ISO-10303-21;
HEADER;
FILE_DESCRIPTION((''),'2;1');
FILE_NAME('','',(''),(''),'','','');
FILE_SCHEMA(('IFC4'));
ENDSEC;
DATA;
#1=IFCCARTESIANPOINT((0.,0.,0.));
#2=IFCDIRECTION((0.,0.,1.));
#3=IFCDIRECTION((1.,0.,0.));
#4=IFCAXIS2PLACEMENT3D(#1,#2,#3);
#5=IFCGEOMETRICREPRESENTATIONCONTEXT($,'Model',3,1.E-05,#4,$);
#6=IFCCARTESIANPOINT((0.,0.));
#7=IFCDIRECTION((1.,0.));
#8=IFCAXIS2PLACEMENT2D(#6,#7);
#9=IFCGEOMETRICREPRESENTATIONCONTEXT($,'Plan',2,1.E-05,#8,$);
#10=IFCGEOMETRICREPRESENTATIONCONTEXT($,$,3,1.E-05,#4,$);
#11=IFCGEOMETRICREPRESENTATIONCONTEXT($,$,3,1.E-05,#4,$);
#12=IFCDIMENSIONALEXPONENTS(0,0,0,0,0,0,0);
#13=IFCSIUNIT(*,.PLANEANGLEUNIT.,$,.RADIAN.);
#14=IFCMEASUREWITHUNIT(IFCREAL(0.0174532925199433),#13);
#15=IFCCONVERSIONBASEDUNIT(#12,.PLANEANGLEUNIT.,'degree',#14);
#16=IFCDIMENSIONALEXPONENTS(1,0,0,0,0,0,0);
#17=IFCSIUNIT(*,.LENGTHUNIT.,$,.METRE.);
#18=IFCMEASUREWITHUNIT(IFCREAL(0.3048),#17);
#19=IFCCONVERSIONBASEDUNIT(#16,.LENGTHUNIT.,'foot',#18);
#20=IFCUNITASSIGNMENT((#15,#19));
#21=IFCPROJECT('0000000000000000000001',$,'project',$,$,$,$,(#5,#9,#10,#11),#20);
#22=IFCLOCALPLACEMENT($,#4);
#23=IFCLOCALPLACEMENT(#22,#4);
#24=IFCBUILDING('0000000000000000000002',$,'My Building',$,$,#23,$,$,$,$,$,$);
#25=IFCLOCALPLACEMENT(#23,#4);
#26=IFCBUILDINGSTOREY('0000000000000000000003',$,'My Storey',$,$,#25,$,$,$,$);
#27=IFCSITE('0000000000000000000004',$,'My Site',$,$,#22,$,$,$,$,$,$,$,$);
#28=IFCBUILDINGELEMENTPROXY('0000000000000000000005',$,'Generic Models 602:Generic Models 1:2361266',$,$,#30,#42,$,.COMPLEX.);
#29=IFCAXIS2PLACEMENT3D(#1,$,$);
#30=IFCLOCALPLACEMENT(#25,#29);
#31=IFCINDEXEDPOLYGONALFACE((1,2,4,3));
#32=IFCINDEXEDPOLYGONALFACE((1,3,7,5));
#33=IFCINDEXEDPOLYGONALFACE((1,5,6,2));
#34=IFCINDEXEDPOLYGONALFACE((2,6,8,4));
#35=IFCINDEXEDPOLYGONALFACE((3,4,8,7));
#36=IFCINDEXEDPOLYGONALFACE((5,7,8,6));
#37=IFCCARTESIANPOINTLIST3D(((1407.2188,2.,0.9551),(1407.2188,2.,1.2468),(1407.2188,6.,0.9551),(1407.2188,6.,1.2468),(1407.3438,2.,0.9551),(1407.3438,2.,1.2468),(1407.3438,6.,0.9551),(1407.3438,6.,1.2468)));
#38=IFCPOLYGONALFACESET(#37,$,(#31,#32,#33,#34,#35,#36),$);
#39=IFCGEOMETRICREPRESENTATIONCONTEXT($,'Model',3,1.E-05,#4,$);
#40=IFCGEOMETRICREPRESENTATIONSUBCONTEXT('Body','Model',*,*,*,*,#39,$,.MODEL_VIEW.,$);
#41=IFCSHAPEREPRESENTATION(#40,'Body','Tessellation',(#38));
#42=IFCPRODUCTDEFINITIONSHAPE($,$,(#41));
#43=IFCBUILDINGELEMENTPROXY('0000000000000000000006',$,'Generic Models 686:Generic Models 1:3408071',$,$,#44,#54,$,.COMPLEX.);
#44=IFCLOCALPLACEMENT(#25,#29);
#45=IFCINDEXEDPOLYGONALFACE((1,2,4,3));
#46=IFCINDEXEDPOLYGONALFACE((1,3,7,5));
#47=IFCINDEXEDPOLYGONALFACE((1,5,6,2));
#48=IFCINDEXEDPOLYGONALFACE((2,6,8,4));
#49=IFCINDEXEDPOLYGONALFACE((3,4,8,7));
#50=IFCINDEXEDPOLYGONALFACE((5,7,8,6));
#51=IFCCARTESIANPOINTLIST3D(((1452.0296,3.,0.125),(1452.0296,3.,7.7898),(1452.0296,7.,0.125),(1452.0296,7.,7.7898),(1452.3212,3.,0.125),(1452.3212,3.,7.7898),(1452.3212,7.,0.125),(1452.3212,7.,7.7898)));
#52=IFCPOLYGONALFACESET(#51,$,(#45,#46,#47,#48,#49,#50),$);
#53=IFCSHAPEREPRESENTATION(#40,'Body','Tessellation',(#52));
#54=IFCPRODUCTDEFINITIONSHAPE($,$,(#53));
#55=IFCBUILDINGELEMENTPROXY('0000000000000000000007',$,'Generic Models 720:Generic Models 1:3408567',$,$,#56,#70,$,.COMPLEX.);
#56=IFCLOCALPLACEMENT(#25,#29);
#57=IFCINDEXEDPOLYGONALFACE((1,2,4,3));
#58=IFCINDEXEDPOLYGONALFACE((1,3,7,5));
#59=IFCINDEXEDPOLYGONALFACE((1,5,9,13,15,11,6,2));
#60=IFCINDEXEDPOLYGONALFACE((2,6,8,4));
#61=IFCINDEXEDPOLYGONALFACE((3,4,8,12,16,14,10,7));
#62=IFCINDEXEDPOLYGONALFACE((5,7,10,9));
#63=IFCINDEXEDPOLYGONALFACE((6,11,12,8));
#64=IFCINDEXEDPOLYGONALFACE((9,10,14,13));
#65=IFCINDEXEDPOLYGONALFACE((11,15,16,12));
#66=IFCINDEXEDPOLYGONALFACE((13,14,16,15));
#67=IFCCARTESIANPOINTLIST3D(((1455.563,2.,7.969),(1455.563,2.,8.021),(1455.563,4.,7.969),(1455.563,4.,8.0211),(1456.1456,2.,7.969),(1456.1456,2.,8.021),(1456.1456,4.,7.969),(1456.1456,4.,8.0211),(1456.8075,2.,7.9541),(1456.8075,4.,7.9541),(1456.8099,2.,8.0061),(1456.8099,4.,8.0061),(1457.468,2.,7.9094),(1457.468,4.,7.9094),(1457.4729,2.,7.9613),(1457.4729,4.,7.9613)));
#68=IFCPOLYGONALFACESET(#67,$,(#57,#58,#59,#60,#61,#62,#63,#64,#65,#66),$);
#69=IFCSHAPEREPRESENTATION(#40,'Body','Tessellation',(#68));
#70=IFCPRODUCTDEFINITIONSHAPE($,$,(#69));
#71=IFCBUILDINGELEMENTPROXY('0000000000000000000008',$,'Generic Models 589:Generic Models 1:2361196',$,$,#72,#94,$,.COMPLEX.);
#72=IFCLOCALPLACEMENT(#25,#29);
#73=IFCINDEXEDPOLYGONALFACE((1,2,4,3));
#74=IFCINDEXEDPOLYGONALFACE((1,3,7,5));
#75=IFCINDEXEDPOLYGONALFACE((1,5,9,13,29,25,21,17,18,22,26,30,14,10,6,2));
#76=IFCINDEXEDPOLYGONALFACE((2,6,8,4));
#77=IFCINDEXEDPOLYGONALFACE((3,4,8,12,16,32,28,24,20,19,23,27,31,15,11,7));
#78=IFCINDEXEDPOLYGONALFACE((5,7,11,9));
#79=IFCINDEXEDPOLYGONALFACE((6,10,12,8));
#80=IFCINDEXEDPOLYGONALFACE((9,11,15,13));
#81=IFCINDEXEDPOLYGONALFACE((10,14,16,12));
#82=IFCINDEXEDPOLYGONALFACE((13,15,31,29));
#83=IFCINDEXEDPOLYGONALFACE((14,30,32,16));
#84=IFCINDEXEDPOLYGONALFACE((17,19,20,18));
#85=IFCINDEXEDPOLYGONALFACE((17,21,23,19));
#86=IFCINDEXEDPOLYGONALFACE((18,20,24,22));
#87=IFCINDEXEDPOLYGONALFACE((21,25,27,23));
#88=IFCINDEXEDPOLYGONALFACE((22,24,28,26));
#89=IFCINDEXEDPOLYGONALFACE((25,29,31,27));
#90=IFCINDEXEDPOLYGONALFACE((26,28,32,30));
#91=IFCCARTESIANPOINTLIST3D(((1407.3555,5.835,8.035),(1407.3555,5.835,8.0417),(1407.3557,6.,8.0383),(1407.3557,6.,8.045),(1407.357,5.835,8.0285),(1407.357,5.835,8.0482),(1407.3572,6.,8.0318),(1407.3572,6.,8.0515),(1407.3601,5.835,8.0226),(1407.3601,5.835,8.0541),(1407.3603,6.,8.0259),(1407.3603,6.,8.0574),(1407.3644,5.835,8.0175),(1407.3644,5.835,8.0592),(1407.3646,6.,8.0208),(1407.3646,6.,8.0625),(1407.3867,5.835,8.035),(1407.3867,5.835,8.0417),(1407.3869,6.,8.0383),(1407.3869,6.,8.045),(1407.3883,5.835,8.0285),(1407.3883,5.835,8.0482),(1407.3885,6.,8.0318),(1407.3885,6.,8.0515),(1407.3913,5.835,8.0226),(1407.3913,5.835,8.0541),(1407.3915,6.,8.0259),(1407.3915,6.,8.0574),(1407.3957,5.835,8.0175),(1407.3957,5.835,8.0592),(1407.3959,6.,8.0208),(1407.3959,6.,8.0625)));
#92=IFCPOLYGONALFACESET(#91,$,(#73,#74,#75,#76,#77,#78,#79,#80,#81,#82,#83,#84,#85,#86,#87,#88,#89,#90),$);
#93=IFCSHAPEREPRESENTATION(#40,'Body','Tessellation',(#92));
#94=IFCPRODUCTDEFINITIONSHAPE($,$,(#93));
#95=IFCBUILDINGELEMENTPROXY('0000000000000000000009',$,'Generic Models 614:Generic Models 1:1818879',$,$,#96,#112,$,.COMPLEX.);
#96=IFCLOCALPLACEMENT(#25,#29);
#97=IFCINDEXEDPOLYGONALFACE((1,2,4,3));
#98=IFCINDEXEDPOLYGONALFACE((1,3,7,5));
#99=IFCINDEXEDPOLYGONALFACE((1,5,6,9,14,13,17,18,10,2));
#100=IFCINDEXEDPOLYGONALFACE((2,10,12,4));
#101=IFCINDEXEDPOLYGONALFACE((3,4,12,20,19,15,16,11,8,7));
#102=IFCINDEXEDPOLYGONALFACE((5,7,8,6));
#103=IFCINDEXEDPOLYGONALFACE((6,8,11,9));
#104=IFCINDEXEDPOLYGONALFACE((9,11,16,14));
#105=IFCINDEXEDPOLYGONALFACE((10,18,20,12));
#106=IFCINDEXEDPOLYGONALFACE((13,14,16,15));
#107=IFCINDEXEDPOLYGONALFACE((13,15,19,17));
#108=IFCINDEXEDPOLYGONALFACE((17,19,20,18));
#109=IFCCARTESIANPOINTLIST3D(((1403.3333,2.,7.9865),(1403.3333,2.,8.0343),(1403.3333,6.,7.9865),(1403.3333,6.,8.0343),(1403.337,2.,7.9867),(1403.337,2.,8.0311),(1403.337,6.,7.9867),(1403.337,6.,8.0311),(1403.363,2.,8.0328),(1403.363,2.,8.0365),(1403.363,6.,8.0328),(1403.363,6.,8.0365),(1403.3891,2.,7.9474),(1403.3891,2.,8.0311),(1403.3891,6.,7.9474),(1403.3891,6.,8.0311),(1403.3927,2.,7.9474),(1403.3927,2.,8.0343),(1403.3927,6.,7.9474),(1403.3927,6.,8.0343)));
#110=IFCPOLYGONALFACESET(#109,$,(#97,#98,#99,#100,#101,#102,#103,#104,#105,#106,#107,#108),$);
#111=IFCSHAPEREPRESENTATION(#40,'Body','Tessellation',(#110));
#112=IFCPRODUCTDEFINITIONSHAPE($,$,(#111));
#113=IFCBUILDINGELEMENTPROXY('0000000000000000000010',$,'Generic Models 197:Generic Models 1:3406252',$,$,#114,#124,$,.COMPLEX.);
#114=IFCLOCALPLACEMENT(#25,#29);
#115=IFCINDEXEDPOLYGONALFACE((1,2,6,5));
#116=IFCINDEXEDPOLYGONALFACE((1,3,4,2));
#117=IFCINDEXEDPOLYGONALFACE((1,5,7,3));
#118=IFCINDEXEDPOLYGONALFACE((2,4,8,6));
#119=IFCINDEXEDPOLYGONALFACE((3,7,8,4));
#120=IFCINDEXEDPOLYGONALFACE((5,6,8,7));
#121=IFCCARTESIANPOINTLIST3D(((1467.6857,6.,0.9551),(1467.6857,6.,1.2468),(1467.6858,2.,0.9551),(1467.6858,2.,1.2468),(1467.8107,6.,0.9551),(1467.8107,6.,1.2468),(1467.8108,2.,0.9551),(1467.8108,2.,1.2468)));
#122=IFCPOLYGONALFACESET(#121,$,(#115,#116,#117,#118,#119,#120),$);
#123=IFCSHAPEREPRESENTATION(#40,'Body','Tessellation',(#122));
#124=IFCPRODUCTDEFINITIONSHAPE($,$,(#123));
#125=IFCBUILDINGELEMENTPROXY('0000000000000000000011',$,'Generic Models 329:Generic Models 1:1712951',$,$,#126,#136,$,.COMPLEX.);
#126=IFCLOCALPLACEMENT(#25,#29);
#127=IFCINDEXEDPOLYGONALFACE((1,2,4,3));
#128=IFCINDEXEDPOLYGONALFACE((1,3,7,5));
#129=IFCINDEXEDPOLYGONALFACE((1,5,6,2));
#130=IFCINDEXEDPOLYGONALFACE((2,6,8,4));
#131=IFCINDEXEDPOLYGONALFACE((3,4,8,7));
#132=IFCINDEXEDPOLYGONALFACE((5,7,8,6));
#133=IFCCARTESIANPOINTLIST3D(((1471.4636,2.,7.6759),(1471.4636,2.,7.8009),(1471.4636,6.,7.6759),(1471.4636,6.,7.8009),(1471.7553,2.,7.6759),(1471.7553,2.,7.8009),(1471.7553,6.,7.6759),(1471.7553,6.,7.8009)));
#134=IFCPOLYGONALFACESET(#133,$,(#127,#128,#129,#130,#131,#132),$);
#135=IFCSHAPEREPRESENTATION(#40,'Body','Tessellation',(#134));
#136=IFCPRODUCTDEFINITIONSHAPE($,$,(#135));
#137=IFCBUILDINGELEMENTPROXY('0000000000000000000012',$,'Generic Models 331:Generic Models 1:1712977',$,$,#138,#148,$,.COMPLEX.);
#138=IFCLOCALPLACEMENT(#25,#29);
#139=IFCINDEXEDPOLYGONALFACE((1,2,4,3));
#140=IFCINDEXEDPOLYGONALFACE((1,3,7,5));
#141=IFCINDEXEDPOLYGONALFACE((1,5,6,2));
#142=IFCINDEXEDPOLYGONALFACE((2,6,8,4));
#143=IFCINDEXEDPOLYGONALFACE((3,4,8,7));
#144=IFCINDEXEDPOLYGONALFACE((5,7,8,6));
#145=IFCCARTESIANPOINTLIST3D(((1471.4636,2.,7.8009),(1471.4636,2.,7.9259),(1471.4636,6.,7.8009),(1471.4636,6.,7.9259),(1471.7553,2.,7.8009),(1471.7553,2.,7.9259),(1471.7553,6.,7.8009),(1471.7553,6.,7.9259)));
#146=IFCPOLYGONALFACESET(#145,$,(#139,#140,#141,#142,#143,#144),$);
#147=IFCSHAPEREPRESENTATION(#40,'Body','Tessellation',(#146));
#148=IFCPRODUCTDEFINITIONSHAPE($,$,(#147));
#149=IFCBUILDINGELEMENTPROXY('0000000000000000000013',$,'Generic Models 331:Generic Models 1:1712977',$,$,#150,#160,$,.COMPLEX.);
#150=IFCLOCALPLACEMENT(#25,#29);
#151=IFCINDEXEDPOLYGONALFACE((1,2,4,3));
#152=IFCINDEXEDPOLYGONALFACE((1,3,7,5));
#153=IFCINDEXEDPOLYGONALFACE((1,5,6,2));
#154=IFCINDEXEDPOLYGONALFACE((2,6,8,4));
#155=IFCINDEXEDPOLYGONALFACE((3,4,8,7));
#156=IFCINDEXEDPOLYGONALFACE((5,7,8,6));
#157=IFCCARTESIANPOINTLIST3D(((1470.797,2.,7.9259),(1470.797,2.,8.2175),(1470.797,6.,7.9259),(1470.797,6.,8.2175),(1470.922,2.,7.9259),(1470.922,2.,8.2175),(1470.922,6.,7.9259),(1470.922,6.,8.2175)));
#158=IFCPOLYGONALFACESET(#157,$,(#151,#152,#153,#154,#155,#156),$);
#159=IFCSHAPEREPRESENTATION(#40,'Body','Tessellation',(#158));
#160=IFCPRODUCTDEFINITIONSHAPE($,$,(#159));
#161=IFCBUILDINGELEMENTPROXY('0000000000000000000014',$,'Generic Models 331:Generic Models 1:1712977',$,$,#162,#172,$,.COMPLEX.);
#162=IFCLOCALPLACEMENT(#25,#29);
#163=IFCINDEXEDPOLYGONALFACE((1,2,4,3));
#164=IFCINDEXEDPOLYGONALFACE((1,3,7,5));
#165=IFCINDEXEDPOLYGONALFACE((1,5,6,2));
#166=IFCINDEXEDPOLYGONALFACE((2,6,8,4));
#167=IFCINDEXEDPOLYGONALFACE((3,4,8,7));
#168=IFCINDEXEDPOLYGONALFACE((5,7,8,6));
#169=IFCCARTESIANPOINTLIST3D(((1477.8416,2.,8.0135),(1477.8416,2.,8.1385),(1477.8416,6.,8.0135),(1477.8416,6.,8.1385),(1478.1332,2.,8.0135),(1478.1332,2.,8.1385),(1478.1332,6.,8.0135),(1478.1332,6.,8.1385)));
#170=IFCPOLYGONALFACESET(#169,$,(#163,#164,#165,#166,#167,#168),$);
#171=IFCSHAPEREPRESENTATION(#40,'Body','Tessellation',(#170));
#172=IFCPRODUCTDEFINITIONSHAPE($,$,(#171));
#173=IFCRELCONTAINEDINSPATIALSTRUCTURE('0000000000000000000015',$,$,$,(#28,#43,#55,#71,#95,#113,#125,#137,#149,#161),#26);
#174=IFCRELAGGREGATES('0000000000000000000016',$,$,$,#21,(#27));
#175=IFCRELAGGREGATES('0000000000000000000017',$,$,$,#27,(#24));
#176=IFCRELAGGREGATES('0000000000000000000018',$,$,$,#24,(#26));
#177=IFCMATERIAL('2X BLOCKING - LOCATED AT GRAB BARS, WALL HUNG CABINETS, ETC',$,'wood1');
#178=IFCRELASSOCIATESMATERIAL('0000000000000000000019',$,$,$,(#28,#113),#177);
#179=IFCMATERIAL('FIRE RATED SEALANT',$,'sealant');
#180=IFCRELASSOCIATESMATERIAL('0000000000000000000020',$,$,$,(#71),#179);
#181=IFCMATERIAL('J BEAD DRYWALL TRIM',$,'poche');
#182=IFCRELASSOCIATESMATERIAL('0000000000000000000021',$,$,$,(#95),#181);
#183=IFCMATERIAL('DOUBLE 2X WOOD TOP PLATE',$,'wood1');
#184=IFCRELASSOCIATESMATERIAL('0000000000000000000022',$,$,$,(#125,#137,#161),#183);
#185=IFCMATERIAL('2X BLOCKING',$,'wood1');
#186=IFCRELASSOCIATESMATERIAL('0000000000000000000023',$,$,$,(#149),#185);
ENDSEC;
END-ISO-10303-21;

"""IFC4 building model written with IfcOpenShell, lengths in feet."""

from ifc_helpers import new_model, entity, si_unit, converted_unit, frame, origin_with_axes, origin_2d_with_axis, place, context, subcontext, project, spatial, polyline, line, indexed_curve, outline, extrude, material, element, save


model = new_model("IFC4")

# Units and contexts
model_context_1 = context("Model", 3, precision=1e-05, world=origin_with_axes())
plan_context = context("Plan", 2, precision=1e-05, world=origin_2d_with_axis())
model_context_2 = context("Model", 3, precision=1e-05, world=origin_with_axes())
context_of_model_1 = context(None, 3, precision=1e-05, world=origin_with_axes())
context_of_model_2 = context(None, 3, precision=1e-05, world=origin_with_axes())
body_context = subcontext(model_context_2, "Body", "Model", "MODEL_VIEW")
ifc_project = project(units=[converted_unit("PLANEANGLEUNIT", "degree", entity("IfcReal", 0.0174532925199433), si_unit("PLANEANGLEUNIT", "RADIAN"), dimensions=[0, 0, 0, 0, 0, 0, 0]), converted_unit("LENGTHUNIT", "foot", entity("IfcReal", 0.3048), si_unit("LENGTHUNIT", "METRE"), dimensions=[1, 0, 0, 0, 0, 0, 0])], contexts=[model_context_1, plan_context, context_of_model_1, context_of_model_2])

# Site, building, storey
site_placement = place(None, origin_with_axes())
site = spatial("IfcSite", under=ifc_project, at=site_placement, Name="My Site")
building_placement = place(site_placement, origin_with_axes())
building = spatial("IfcBuilding", under=site, at=building_placement, Name="My Building")
storey_placement = place(building_placement, origin_with_axes())
storey = spatial("IfcBuildingStorey", under=building, at=storey_placement, Name="My Storey")

# Building element proxies
ifc_material_1 = material(Name="2X BLOCKING - LOCATED AT GRAB BARS, WALL HUNG CABINETS, ETC", Category="wood1")
proxy_1_placement = place(storey_placement, frame((1407.2188, 6.0, 0.9551), z_axis=(0.0, -1.0, 0.0), x_axis=(0.0, 0.0, 1.0)))
element("IfcBuildingElementProxy", 1, at=proxy_1_placement, inside=storey, material=ifc_material_1, Name="Generic Models 602:Generic Models 1:2361266", PredefinedType="COMPLEX", context=body_context, shape_type="SweptSolid", body=[
    extrude(outline(polyline([(-0.1458, -0.0625), (0.1458, -0.0625), (0.1458, 0.0625), (-0.1458, 0.0625), (-0.1458, -0.0625)])), frame((0.1458, -0.0625, 0.0), z_axis=(0.0, 0.0, -1.0), x_axis=(1.0, 0.0, 0.0)), (0.0, 0.0, -1.0), 4.0),
])
proxy_2_placement = place(storey_placement, frame((1452.0296, 7.0, 0.125), z_axis=(0.0, -1.0, 0.0), x_axis=(0.0, 0.0, 1.0)))
element("IfcBuildingElementProxy", 2, at=proxy_2_placement, inside=storey, Name="Generic Models 686:Generic Models 1:3408071", PredefinedType="COMPLEX", context=body_context, shape_type="SweptSolid", body=[
    extrude(outline(polyline([(-3.8324, -0.1458), (3.8324, -0.1458), (3.8324, 0.1458), (-3.8324, 0.1458), (-3.8324, -0.1458)])), frame((3.8324, -0.1458, 0.0), z_axis=(0.0, 0.0, -1.0), x_axis=(1.0, 0.0, 0.0)), (0.0, 0.0, -1.0), 4.0),
])
proxy_3_placement = place(storey_placement, frame((1455.563, 6.0, 7.9094), z_axis=(0.0, -1.0, 0.0), x_axis=(0.0, 0.0, 1.0)))
element("IfcBuildingElementProxy", 3, at=proxy_3_placement, inside=storey, Name="Generic Models 720:Generic Models 1:3408567", PredefinedType="COMPLEX", context=body_context, shape_type="SweptSolid", body=[
    extrude(outline(polyline([(-0.0074, -0.9339), (0.0447, -0.9339), (0.0447, -0.3513), (0.0297, 0.313), (-0.0151, 0.9759), (-0.0669, 0.9711), (-0.0223, 0.3105), (-0.0074, -0.3513), (-0.0074, -0.9339)])), frame((0.0669, -0.9339, 2.0), z_axis=(0.000003, 0.0, -1.0), x_axis=(1.0, 0.0, 0.0)), (0.0, 0.0, -1.0), 2.0),
])
ifc_material_2 = material(Name="FIRE RATED SEALANT", Category="sealant")
proxy_4_placement = place(storey_placement, frame((1407.3557, 6.0, 8.0208), z_axis=(0.0, -1.0, 0.0), x_axis=(0.0, 0.0, 1.0)))
element("IfcBuildingElementProxy", 4, at=proxy_4_placement, inside=storey, material=ifc_material_2, Name="Generic Models 589:Generic Models 1:2361196", PredefinedType="COMPLEX", context=body_context, shape_type="SweptSolid", body=[
    extrude(outline(polyline([(0.0204, 0.0), (0.0206, 0.0067), (0.0192, 0.0132), (-0.0082, 0.0283), (-0.0068, 0.0217), (-0.007, 0.0151), (-0.0088, 0.0086), (-0.012, 0.0028), (-0.0165, -0.0021), (-0.022, -0.0059), (-0.0283, -0.0082), (-0.0009, -0.0233), (0.0054, -0.021), (0.0109, -0.0172), (0.0154, -0.0123), (0.0186, -0.0064), (0.0204, 0.0)])), frame((0.0208, -0.0194, 0.0), z_axis=(0.0, 0.0, -1.0), x_axis=(0.482454, 0.875921, 0.0)), (-0.008711, -0.018298, -0.999795), 0.165),
])
ifc_material_3 = material(Name="J BEAD DRYWALL TRIM", Category="poche")
proxy_5_placement = place(storey_placement, frame((1403.3333, 6.0, 7.9474), z_axis=(0.0, -1.0, 0.0), x_axis=(0.0, 0.0, 1.0)))
element("IfcBuildingElementProxy", 5, at=proxy_5_placement, inside=storey, material=ifc_material_3, Name="Generic Models 614:Generic Models 1:1818879", PredefinedType="COMPLEX", context=body_context, shape_type="SweptSolid", body=[
    extrude(outline(indexed_curve([(-0.0203, -0.0297), (0.0275, -0.0297), (0.0296, 0.0), (0.0275, 0.0297), (-0.0594, 0.0297), (-0.0594, 0.026), (0.0243, 0.026), (0.026, 0.0), (0.0243, -0.026), (-0.0201, -0.026)], segments=[line(3, 2), line(2, 1), line(1, 10), line(10, 9), line(9, 8), line(8, 7), line(7, 6), line(6, 5), line(5, 4), line(4, 3)], self_intersect=False)), frame((0.0594, -0.0297, 0.0), z_axis=(0.0, 0.0, -1.0), x_axis=(1.0, 0.0, 0.0)), (0.0, 0.0, -1.0), 4.0),
])
for number, where, z_axis, x_axis, name in (
    (6, (1467.6857, 6.0, 0.9551), (0.0, -1.0, 0.0), (0.0, 0.0, 1.0), "Generic Models 197:Generic Models 1:3406252"),
):
    element("IfcBuildingElementProxy", number, at=place(storey_placement, frame(where, z_axis=z_axis, x_axis=x_axis)), inside=storey, material=ifc_material_1, Name=name, PredefinedType="COMPLEX", context=body_context, shape_type="SweptSolid", body=[
        extrude(outline(polyline([(-0.0625, -0.1458), (0.0625, -0.1458), (0.0625, 0.1458), (-0.0625, 0.1458), (-0.0625, -0.1458)])), frame((0.1458, -0.0625, 0.0), z_axis=(0.0, 0.0, -1.0), x_axis=(0.0, 1.0, 0.0)), (0.0, 0.0, -1.0), 4.0),
    ])
ifc_material_4 = material(Name="DOUBLE 2X WOOD TOP PLATE", Category="wood1")
proxy_6_placement = place(storey_placement, frame((1471.4636, 6.0, 7.6759), z_axis=(0.0, -1.0, 0.0), x_axis=(0.0, 0.0, 1.0)))
element("IfcBuildingElementProxy", 7, at=proxy_6_placement, inside=storey, material=ifc_material_4, Name="Generic Models 329:Generic Models 1:1712951", PredefinedType="COMPLEX", context=body_context, shape_type="SweptSolid", body=[
    extrude(outline(indexed_curve([(-0.1458, -0.0625), (0.1458, -0.0625), (0.1458, 0.0625), (-0.1458, 0.0625)], segments=[line(3, 2), line(2, 1), line(1, 4), line(4, 3)], self_intersect=False)), frame((0.0625, -0.1458, 0.0), z_axis=(0.0, 0.0, -1.0), x_axis=(0.0, 1.0, 0.0)), (0.0, 0.0, -1.0), 4.0),
])
proxy_7_placement = place(storey_placement, frame((1471.4636, 6.0, 7.8009), z_axis=(0.0, -1.0, 0.0), x_axis=(0.0, 0.0, 1.0)))
element("IfcBuildingElementProxy", 8, at=proxy_7_placement, inside=storey, material=ifc_material_4, Name="Generic Models 331:Generic Models 1:1712977", PredefinedType="COMPLEX", context=body_context, shape_type="SweptSolid", body=[
    extrude(outline(polyline([(-0.1458, -0.0625), (0.1458, -0.0625), (0.1458, 0.0625), (-0.1458, 0.0625), (-0.1458, -0.0625)])), frame((0.0625, -0.1458, 0.0), z_axis=(0.0, 0.0, -1.0), x_axis=(0.0, 1.0, 0.0)), (0.0, 0.0, -1.0), 4.0),
])
ifc_material_5 = material(Name="2X BLOCKING", Category="wood1")
proxy_8_placement = place(storey_placement, frame((1470.922, 6.0, 7.9259), z_axis=(0.0, -1.0, 0.0), x_axis=(-1.0, 0.0, 0.0)))
element("IfcBuildingElementProxy", 9, at=proxy_8_placement, inside=storey, material=ifc_material_5, Name="Generic Models 331:Generic Models 1:1712977", PredefinedType="COMPLEX", context=body_context, shape_type="SweptSolid", body=[
    extrude(outline(polyline([(-0.1458, -0.0625), (0.1458, -0.0625), (0.1458, 0.0625), (-0.1458, 0.0625), (-0.1458, -0.0625)])), frame((0.0625, -0.1458, 0.0), z_axis=(0.0, 0.0, -1.0), x_axis=(0.0, -1.0, 0.0)), (0.0, 0.0, -1.0), 4.0),
])
proxy_9_placement = place(storey_placement, frame((1477.8416, 6.0, 8.0135), z_axis=(0.0, -1.0, 0.0), x_axis=(0.0, 0.0, 1.0)))
element("IfcBuildingElementProxy", 10, at=proxy_9_placement, inside=storey, material=ifc_material_4, Name="Generic Models 331:Generic Models 1:1712977", PredefinedType="COMPLEX", context=body_context, shape_type="SweptSolid", body=[
    extrude(outline(polyline([(-0.1458, -0.0625), (0.1458, -0.0625), (0.1458, 0.0625), (-0.1458, 0.0625), (-0.1458, -0.0625)])), frame((0.0625, -0.1458, 0.0), z_axis=(0.0, 0.0, -1.0), x_axis=(0.0, -1.0, 0.0)), (0.0, 0.0, -1.0), 4.0),
])

save(model, "model.ifc")
